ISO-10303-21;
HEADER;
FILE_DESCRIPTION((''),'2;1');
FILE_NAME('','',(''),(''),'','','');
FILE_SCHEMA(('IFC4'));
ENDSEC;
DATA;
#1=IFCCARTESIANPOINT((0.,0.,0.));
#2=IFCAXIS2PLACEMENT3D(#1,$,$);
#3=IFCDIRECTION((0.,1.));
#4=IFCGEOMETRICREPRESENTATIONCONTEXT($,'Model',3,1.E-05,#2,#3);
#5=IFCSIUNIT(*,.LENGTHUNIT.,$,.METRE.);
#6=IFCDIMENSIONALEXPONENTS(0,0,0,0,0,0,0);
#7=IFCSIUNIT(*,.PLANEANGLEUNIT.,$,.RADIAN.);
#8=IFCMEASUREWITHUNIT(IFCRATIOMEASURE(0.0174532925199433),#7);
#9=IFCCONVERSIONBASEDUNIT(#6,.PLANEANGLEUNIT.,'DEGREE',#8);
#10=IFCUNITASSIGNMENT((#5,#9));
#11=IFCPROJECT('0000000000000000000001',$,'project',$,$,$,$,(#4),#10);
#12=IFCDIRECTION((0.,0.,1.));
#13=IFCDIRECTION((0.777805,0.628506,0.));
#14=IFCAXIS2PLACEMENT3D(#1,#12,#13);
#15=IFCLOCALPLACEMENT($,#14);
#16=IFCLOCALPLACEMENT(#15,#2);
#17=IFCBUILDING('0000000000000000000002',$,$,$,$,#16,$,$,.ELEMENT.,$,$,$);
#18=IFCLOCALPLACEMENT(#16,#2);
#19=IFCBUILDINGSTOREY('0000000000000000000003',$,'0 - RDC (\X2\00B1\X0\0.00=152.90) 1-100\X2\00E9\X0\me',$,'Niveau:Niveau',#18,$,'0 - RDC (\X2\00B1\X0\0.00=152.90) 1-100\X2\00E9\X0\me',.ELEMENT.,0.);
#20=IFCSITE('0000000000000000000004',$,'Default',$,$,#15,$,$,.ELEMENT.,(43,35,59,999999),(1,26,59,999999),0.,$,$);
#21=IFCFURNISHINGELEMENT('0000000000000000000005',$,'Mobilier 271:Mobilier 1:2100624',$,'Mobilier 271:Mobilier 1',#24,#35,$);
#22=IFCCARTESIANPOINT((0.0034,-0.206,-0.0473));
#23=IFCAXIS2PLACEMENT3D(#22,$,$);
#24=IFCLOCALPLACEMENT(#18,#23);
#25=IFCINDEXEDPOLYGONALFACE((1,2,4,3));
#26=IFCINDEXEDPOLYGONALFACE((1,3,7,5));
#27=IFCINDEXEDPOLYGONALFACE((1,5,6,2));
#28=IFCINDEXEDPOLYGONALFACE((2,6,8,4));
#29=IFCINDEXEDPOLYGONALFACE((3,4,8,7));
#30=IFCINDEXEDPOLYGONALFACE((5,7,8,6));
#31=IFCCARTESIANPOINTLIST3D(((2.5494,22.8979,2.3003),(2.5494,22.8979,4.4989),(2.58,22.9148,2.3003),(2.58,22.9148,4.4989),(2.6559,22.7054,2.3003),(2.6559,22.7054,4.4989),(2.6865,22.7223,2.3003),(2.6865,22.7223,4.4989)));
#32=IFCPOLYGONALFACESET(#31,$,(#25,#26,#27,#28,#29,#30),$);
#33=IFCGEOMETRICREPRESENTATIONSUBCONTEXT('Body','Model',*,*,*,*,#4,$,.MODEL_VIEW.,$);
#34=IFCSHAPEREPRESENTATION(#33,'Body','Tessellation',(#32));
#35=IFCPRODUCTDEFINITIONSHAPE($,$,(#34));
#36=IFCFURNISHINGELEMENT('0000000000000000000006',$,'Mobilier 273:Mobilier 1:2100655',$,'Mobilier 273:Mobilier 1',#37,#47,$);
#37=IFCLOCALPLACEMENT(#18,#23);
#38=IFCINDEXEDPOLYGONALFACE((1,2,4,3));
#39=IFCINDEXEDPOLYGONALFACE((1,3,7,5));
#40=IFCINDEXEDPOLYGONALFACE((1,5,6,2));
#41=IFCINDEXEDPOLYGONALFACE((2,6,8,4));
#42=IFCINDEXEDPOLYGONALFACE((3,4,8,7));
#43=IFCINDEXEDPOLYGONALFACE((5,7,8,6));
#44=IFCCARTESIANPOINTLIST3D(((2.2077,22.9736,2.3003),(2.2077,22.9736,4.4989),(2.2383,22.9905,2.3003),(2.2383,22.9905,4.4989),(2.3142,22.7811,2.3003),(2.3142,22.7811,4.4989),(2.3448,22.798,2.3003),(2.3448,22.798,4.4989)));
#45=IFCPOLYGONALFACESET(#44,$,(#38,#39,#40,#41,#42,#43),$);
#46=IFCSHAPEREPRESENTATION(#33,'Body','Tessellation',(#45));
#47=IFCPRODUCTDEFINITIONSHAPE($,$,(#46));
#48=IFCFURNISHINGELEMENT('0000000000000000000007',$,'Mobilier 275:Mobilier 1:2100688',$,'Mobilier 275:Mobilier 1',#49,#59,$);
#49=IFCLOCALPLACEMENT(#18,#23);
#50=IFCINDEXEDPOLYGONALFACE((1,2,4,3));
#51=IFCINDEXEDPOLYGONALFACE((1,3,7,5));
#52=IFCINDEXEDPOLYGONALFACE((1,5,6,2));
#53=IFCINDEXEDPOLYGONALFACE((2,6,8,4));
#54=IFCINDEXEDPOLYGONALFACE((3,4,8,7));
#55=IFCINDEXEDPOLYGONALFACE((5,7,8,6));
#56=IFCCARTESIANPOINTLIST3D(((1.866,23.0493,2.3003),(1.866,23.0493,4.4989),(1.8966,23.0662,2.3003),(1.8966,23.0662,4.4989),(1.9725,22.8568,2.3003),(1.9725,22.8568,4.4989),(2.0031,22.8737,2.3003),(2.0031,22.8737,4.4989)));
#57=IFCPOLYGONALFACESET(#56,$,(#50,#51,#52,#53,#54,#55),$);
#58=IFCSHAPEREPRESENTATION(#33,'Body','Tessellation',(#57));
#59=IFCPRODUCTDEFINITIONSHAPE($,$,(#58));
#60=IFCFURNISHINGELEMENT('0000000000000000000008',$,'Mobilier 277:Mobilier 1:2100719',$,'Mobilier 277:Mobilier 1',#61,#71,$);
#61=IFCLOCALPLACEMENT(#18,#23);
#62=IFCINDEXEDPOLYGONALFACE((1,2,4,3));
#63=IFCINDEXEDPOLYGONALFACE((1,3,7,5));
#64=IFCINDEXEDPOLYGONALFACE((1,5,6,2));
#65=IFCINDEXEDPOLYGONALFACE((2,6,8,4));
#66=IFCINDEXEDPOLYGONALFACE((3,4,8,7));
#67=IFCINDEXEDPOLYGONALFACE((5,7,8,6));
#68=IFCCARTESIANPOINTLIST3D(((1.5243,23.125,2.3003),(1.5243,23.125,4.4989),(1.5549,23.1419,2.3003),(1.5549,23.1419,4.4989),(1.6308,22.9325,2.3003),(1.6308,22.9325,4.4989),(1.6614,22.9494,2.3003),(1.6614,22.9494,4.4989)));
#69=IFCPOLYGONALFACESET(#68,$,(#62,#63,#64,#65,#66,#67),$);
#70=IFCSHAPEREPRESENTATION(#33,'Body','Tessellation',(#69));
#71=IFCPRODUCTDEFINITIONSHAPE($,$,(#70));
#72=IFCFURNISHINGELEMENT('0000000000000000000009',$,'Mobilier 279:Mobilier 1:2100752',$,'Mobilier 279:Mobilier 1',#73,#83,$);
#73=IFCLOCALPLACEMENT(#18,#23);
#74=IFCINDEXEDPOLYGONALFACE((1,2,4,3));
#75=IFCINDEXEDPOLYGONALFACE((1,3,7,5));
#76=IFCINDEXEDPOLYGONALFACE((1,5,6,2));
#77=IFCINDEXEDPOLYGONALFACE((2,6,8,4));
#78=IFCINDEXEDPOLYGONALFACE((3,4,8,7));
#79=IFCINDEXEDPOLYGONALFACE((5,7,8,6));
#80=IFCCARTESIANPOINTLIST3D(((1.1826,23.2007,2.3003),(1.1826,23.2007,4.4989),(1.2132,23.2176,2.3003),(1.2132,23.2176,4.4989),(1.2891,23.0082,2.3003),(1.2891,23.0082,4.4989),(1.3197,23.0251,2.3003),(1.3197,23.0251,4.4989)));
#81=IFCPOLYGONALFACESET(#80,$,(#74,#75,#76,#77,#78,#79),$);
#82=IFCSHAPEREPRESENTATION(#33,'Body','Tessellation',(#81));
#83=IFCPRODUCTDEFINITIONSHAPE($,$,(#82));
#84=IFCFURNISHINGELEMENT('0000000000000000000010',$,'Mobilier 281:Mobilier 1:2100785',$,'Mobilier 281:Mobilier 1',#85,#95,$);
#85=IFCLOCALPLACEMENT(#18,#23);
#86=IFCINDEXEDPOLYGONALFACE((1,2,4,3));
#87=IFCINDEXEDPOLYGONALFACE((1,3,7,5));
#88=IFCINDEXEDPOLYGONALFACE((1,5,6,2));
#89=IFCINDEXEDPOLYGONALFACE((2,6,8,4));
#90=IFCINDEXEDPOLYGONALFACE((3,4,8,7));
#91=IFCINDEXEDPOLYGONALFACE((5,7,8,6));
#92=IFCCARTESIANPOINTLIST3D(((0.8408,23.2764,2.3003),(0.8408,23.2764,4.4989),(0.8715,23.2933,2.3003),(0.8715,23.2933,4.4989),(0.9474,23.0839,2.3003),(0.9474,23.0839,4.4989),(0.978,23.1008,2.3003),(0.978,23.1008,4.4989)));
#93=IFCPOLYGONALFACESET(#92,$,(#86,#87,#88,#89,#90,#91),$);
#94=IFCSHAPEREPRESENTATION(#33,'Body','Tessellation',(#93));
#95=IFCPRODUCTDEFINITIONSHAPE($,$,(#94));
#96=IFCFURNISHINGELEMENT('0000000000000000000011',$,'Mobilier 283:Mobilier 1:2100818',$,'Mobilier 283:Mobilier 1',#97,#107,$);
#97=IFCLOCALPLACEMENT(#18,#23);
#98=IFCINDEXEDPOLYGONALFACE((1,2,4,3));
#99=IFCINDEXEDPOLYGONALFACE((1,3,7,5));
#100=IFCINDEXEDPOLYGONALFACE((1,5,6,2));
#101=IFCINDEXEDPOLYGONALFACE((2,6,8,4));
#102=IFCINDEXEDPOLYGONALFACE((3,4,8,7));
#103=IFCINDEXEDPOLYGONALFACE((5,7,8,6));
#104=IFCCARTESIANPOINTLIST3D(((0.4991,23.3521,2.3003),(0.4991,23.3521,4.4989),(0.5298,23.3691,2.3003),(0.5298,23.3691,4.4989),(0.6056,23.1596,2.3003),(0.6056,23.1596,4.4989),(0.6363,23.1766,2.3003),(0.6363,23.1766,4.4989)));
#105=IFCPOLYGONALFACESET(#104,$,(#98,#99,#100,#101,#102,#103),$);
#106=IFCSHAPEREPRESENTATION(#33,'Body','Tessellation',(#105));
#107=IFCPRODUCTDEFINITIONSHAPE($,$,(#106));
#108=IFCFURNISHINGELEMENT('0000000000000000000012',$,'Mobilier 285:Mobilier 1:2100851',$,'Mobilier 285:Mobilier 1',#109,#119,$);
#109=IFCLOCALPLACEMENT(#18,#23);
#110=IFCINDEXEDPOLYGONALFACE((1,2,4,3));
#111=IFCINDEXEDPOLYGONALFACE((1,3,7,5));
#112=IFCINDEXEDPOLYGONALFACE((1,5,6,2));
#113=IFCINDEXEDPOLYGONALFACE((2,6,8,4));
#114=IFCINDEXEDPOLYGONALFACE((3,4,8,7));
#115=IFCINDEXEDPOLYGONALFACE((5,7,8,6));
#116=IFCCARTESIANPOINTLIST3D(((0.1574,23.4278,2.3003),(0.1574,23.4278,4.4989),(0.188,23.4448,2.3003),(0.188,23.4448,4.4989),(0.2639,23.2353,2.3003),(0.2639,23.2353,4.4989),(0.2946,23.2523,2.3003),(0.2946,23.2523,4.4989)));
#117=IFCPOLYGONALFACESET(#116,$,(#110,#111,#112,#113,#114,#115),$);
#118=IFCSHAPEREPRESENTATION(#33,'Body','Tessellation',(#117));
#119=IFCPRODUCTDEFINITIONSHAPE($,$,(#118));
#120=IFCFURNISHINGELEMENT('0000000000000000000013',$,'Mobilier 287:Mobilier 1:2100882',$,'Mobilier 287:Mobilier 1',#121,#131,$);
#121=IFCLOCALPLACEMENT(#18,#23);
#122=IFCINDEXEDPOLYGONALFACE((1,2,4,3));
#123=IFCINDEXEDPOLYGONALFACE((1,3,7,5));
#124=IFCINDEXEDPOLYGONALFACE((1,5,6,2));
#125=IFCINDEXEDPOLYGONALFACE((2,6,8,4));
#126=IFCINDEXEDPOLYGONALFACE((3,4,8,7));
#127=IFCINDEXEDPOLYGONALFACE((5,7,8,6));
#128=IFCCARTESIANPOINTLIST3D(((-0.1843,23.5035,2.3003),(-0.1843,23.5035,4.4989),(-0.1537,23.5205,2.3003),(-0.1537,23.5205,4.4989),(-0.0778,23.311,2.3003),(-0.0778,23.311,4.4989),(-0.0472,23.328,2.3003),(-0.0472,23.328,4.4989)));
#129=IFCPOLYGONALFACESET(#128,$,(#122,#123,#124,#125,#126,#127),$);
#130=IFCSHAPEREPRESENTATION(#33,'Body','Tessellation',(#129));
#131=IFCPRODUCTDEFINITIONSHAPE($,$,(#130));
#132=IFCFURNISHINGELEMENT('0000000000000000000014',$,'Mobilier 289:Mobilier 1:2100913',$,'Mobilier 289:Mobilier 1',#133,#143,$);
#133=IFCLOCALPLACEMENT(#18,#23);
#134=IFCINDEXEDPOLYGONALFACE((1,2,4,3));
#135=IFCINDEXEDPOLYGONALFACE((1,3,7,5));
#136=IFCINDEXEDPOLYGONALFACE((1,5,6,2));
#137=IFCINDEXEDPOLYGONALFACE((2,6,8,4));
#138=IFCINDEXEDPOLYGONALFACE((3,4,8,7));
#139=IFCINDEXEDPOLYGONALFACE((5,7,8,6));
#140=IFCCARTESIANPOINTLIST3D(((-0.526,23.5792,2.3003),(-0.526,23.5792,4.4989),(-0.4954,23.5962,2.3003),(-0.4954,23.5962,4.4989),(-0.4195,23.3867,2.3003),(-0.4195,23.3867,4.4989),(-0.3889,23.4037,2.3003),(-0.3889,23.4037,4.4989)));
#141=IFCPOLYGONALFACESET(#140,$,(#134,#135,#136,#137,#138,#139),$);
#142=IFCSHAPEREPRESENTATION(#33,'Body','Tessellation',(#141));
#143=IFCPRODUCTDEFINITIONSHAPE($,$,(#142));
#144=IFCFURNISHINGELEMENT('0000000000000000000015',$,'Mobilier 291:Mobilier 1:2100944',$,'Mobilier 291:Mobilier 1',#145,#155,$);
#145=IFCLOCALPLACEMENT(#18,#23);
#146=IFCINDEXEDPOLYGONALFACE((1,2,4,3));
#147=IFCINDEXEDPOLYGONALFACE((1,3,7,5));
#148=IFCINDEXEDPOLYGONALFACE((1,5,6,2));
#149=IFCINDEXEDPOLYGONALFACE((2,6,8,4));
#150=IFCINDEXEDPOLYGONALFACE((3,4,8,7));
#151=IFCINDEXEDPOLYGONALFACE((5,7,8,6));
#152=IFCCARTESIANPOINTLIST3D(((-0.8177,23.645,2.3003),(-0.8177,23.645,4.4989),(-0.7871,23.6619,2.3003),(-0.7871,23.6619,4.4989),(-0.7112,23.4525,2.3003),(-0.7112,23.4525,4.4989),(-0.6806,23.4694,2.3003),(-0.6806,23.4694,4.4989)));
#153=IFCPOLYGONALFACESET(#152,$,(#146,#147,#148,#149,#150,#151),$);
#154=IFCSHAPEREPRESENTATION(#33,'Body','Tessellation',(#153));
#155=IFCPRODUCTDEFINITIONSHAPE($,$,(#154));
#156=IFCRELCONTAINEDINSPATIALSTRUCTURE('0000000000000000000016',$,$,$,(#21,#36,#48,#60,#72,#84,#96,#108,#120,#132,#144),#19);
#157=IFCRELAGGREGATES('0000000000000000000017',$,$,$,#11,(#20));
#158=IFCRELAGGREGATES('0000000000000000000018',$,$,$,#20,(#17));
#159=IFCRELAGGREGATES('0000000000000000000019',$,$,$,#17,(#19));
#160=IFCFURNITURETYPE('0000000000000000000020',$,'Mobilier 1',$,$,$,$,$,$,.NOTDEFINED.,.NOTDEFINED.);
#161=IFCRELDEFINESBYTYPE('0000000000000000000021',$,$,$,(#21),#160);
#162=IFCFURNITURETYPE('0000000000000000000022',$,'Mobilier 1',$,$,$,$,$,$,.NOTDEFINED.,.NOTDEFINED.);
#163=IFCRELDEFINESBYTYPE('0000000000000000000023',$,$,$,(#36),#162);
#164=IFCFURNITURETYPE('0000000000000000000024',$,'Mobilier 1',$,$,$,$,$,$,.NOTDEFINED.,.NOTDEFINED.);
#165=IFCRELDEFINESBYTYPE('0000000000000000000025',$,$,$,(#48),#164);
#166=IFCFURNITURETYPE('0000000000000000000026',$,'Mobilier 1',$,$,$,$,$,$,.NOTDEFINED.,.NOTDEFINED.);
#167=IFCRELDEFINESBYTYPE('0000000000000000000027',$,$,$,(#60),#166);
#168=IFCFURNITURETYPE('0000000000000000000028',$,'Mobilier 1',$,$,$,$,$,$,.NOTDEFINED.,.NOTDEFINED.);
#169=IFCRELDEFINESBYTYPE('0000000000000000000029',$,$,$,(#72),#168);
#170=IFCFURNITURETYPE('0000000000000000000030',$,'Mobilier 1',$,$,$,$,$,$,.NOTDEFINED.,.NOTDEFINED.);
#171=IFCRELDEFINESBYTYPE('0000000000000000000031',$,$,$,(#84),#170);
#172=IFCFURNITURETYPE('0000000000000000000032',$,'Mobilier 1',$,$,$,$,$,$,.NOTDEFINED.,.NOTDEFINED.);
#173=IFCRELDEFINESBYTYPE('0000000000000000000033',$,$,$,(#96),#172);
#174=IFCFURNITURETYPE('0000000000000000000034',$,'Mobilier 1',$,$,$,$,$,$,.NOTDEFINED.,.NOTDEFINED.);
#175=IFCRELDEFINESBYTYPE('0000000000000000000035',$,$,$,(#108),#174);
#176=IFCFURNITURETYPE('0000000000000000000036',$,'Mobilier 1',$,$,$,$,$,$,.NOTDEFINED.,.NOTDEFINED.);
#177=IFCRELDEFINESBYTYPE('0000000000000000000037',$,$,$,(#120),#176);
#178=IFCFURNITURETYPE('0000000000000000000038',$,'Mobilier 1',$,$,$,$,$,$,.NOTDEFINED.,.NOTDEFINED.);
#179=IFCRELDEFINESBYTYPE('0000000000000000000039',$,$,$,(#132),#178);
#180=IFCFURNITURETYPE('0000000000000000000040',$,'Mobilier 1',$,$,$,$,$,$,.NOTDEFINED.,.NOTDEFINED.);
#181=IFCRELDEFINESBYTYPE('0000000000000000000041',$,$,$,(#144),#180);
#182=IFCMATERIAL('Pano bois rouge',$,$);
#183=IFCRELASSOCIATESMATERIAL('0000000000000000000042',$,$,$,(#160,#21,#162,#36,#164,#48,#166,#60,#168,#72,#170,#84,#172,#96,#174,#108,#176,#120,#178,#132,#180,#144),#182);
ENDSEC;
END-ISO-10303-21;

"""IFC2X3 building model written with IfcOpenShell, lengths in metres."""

from ifc_helpers import new_model, entity, si_unit, converted_unit, direction, frame, frame_2d, origin, origin_2d_with_axis, place, context, subcontext, project, spatial, rectangle, extrude, source, transform, mapped, material, type_object, type_shapes, element, save


model = new_model("IFC2X3")

# Units and contexts
model_context = context("Model", 3, precision=1e-05, world=origin(), true_north=direction((0.0, 1.0)))
body_context = subcontext(model_context, "Body", "Model", "MODEL_VIEW")
ifc_project = project(units=[si_unit("LENGTHUNIT", "METRE"), converted_unit("PLANEANGLEUNIT", "DEGREE", entity("IfcRatioMeasure", 0.0174532925199433), si_unit("PLANEANGLEUNIT", "RADIAN"), dimensions=[0, 0, 0, 0, 0, 0, 0])], contexts=[model_context])

# Site, building, storey
site_placement = place(None, frame((0.0, 0.0, 0.0), z_axis=(0.0, 0.0, 1.0), x_axis=(0.777805, 0.628506, 0.0)))
site = spatial("IfcSite", under=ifc_project, at=site_placement, Name="Default", CompositionType="ELEMENT", RefLatitude=(43, 35, 59, 999999), RefLongitude=(1, 26, 59, 999999), RefElevation=0.0)
building_placement = place(site_placement, origin())
building = spatial("IfcBuilding", under=site, at=building_placement, CompositionType="ELEMENT")
storey_placement = place(building_placement, origin())
storey = spatial("IfcBuildingStorey", under=building, at=storey_placement, Name="0 - RDC (±0.00=152.90) 1-100éme", ObjectType="Niveau:Niveau", LongName="0 - RDC (±0.00=152.90) 1-100éme", CompositionType="ELEMENT", Elevation=0.0)

# Furnishing elements
ifc_material_1 = material(Name="Pano bois rouge")
furniture_type_1 = type_object("IfcFurnitureType", Name="Mobilier 1", material=ifc_material_1)
shared_shape_1 = source(origin(), body_context, "Body", "SweptSolid", [
    extrude(rectangle(XDim=0.035, YDim=0.22, at=origin_2d_with_axis()), frame((2.618, 22.8101, 2.3003), z_axis=(0.0, 0.0, 1.0), x_axis=(-0.875002, -0.484119, 0.0)), (0.0, 0.0, 1.0), 2.1986),
])
type_shapes(furniture_type_1, [shared_shape_1])
furnishing_1_placement = place(storey_placement, frame((0.0034, -0.206, -0.0473)))
element("IfcFurnishingElement", 1, at=furnishing_1_placement, inside=storey, type_object=furniture_type_1, material=ifc_material_1, Name="Mobilier 271:Mobilier 1:2100624", ObjectType="Mobilier 271:Mobilier 1", context=body_context, shape_type="MappedRepresentation", body=[
    mapped(shared_shape_1, transform((0.0, 0.0, 0.0), scale=1.0)),
])
furniture_type_2 = type_object("IfcFurnitureType", Name="Mobilier 1", material=ifc_material_1)
shared_shape_2 = source(origin(), body_context, "Body", "SweptSolid", [
    extrude(rectangle(XDim=0.035, YDim=0.22, at=frame_2d((0.0, 0.0), x_axis=(1.0, 0.0))), frame((2.2763, 22.8858, 2.3003), z_axis=(0.0, 0.0, 1.0), x_axis=(-0.875002, -0.484119, 0.0)), (0.0, 0.0, 1.0), 2.1986),
])
type_shapes(furniture_type_2, [shared_shape_2])
furnishing_2_placement = place(storey_placement, frame((0.0034, -0.206, -0.0473)))
element("IfcFurnishingElement", 2, at=furnishing_2_placement, inside=storey, type_object=furniture_type_2, material=ifc_material_1, Name="Mobilier 273:Mobilier 1:2100655", ObjectType="Mobilier 273:Mobilier 1", context=body_context, shape_type="MappedRepresentation", body=[
    mapped(shared_shape_2, transform((0.0, 0.0, 0.0), scale=1.0)),
])
furniture_type_3 = type_object("IfcFurnitureType", Name="Mobilier 1", material=ifc_material_1)
shared_shape_3 = source(origin(), body_context, "Body", "SweptSolid", [
    extrude(rectangle(XDim=0.035, YDim=0.22, at=frame_2d((0.0, 0.0), x_axis=(1.0, 0.0))), frame((1.9346, 22.9615, 2.3003), z_axis=(0.0, 0.0, 1.0), x_axis=(-0.875002, -0.484119, 0.0)), (0.0, 0.0, 1.0), 2.1986),
])
type_shapes(furniture_type_3, [shared_shape_3])
furnishing_3_placement = place(storey_placement, frame((0.0034, -0.206, -0.0473)))
element("IfcFurnishingElement", 3, at=furnishing_3_placement, inside=storey, type_object=furniture_type_3, material=ifc_material_1, Name="Mobilier 275:Mobilier 1:2100688", ObjectType="Mobilier 275:Mobilier 1", context=body_context, shape_type="MappedRepresentation", body=[
    mapped(shared_shape_3, transform((0.0, 0.0, 0.0), scale=1.0)),
])
furniture_type_4 = type_object("IfcFurnitureType", Name="Mobilier 1", material=ifc_material_1)
shared_shape_4 = source(origin(), body_context, "Body", "SweptSolid", [
    extrude(rectangle(XDim=0.035, YDim=0.22, at=frame_2d((0.0, 0.0), x_axis=(1.0, 0.0))), frame((1.5928, 23.0372, 2.3003), z_axis=(0.0, 0.0, 1.0), x_axis=(-0.875002, -0.484119, 0.0)), (0.0, 0.0, 1.0), 2.1986),
])
type_shapes(furniture_type_4, [shared_shape_4])
furnishing_4_placement = place(storey_placement, frame((0.0034, -0.206, -0.0473)))
element("IfcFurnishingElement", 4, at=furnishing_4_placement, inside=storey, type_object=furniture_type_4, material=ifc_material_1, Name="Mobilier 277:Mobilier 1:2100719", ObjectType="Mobilier 277:Mobilier 1", context=body_context, shape_type="MappedRepresentation", body=[
    mapped(shared_shape_4, transform((0.0, 0.0, 0.0), scale=1.0)),
])
furniture_type_5 = type_object("IfcFurnitureType", Name="Mobilier 1", material=ifc_material_1)
shared_shape_5 = source(origin(), body_context, "Body", "SweptSolid", [
    extrude(rectangle(XDim=0.035, YDim=0.22, at=frame_2d((0.0, 0.0), x_axis=(1.0, 0.0))), frame((1.2511, 23.1129, 2.3003), z_axis=(0.0, 0.0, 1.0), x_axis=(-0.875002, -0.484119, 0.0)), (0.0, 0.0, 1.0), 2.1986),
])
type_shapes(furniture_type_5, [shared_shape_5])
furnishing_5_placement = place(storey_placement, frame((0.0034, -0.206, -0.0473)))
element("IfcFurnishingElement", 5, at=furnishing_5_placement, inside=storey, type_object=furniture_type_5, material=ifc_material_1, Name="Mobilier 279:Mobilier 1:2100752", ObjectType="Mobilier 279:Mobilier 1", context=body_context, shape_type="MappedRepresentation", body=[
    mapped(shared_shape_5, transform((0.0, 0.0, 0.0), scale=1.0)),
])
furniture_type_6 = type_object("IfcFurnitureType", Name="Mobilier 1", material=ifc_material_1)
shared_shape_6 = source(origin(), body_context, "Body", "SweptSolid", [
    extrude(rectangle(XDim=0.035, YDim=0.22, at=frame_2d((0.0, 0.0), x_axis=(1.0, 0.0))), frame((0.9094, 23.1886, 2.3003), z_axis=(0.0, 0.0, 1.0), x_axis=(-0.875002, -0.484119, 0.0)), (0.0, 0.0, 1.0), 2.1986),
])
type_shapes(furniture_type_6, [shared_shape_6])
furnishing_6_placement = place(storey_placement, frame((0.0034, -0.206, -0.0473)))
element("IfcFurnishingElement", 6, at=furnishing_6_placement, inside=storey, type_object=furniture_type_6, material=ifc_material_1, Name="Mobilier 281:Mobilier 1:2100785", ObjectType="Mobilier 281:Mobilier 1", context=body_context, shape_type="MappedRepresentation", body=[
    mapped(shared_shape_6, transform((0.0, 0.0, 0.0), scale=1.0)),
])
furniture_type_7 = type_object("IfcFurnitureType", Name="Mobilier 1", material=ifc_material_1)
shared_shape_7 = source(origin(), body_context, "Body", "SweptSolid", [
    extrude(rectangle(XDim=0.035, YDim=0.22, at=frame_2d((0.0, 0.0), x_axis=(1.0, 0.0))), frame((0.5677, 23.2643, 2.3003), z_axis=(0.0, 0.0, 1.0), x_axis=(-0.875002, -0.484119, 0.0)), (0.0, 0.0, 1.0), 2.1986),
])
type_shapes(furniture_type_7, [shared_shape_7])
furnishing_7_placement = place(storey_placement, frame((0.0034, -0.206, -0.0473)))
element("IfcFurnishingElement", 7, at=furnishing_7_placement, inside=storey, type_object=furniture_type_7, material=ifc_material_1, Name="Mobilier 283:Mobilier 1:2100818", ObjectType="Mobilier 283:Mobilier 1", context=body_context, shape_type="MappedRepresentation", body=[
    mapped(shared_shape_7, transform((0.0, 0.0, 0.0), scale=1.0)),
])
furniture_type_8 = type_object("IfcFurnitureType", Name="Mobilier 1", material=ifc_material_1)
shared_shape_8 = source(origin(), body_context, "Body", "SweptSolid", [
    extrude(rectangle(XDim=0.035, YDim=0.22, at=frame_2d((0.0, 0.0), x_axis=(1.0, 0.0))), frame((0.226, 23.34, 2.3003), z_axis=(0.0, 0.0, 1.0), x_axis=(-0.875002, -0.484119, 0.0)), (0.0, 0.0, 1.0), 2.1986),
])
type_shapes(furniture_type_8, [shared_shape_8])
furnishing_8_placement = place(storey_placement, frame((0.0034, -0.206, -0.0473)))
element("IfcFurnishingElement", 8, at=furnishing_8_placement, inside=storey, type_object=furniture_type_8, material=ifc_material_1, Name="Mobilier 285:Mobilier 1:2100851", ObjectType="Mobilier 285:Mobilier 1", context=body_context, shape_type="MappedRepresentation", body=[
    mapped(shared_shape_8, transform((0.0, 0.0, 0.0), scale=1.0)),
])
furniture_type_9 = type_object("IfcFurnitureType", Name="Mobilier 1", material=ifc_material_1)
shared_shape_9 = source(origin(), body_context, "Body", "SweptSolid", [
    extrude(rectangle(XDim=0.035, YDim=0.22, at=frame_2d((0.0, 0.0), x_axis=(1.0, 0.0))), frame((-0.1157, 23.4158, 2.3003), z_axis=(0.0, 0.0, 1.0), x_axis=(-0.875002, -0.484119, 0.0)), (0.0, 0.0, 1.0), 2.1986),
])
type_shapes(furniture_type_9, [shared_shape_9])
furnishing_9_placement = place(storey_placement, frame((0.0034, -0.206, -0.0473)))
element("IfcFurnishingElement", 9, at=furnishing_9_placement, inside=storey, type_object=furniture_type_9, material=ifc_material_1, Name="Mobilier 287:Mobilier 1:2100882", ObjectType="Mobilier 287:Mobilier 1", context=body_context, shape_type="MappedRepresentation", body=[
    mapped(shared_shape_9, transform((0.0, 0.0, 0.0), scale=1.0)),
])
furniture_type_10 = type_object("IfcFurnitureType", Name="Mobilier 1", material=ifc_material_1)
shared_shape_10 = source(origin(), body_context, "Body", "SweptSolid", [
    extrude(rectangle(XDim=0.035, YDim=0.22, at=frame_2d((0.0, 0.0), x_axis=(1.0, 0.0))), frame((-0.4574, 23.4915, 2.3003), z_axis=(0.0, 0.0, 1.0), x_axis=(-0.875002, -0.484119, 0.0)), (0.0, 0.0, 1.0), 2.1986),
])
type_shapes(furniture_type_10, [shared_shape_10])
furnishing_10_placement = place(storey_placement, frame((0.0034, -0.206, -0.0473)))
element("IfcFurnishingElement", 10, at=furnishing_10_placement, inside=storey, type_object=furniture_type_10, material=ifc_material_1, Name="Mobilier 289:Mobilier 1:2100913", ObjectType="Mobilier 289:Mobilier 1", context=body_context, shape_type="MappedRepresentation", body=[
    mapped(shared_shape_10, transform((0.0, 0.0, 0.0), scale=1.0)),
])
furniture_type_11 = type_object("IfcFurnitureType", Name="Mobilier 1", material=ifc_material_1)
shared_shape_11 = source(origin(), body_context, "Body", "SweptSolid", [
    extrude(rectangle(XDim=0.035, YDim=0.22, at=frame_2d((0.0, 0.0), x_axis=(1.0, 0.0))), frame((-0.7492, 23.5572, 2.3003), z_axis=(0.0, 0.0, 1.0), x_axis=(-0.875002, -0.484119, 0.0)), (0.0, 0.0, 1.0), 2.1986),
])
type_shapes(furniture_type_11, [shared_shape_11])
furnishing_11_placement = place(storey_placement, frame((0.0034, -0.206, -0.0473)))
element("IfcFurnishingElement", 11, at=furnishing_11_placement, inside=storey, type_object=furniture_type_11, material=ifc_material_1, Name="Mobilier 291:Mobilier 1:2100944", ObjectType="Mobilier 291:Mobilier 1", context=body_context, shape_type="MappedRepresentation", body=[
    mapped(shared_shape_11, transform((0.0, 0.0, 0.0), scale=1.0)),
])

save(model, "model.ifc")
